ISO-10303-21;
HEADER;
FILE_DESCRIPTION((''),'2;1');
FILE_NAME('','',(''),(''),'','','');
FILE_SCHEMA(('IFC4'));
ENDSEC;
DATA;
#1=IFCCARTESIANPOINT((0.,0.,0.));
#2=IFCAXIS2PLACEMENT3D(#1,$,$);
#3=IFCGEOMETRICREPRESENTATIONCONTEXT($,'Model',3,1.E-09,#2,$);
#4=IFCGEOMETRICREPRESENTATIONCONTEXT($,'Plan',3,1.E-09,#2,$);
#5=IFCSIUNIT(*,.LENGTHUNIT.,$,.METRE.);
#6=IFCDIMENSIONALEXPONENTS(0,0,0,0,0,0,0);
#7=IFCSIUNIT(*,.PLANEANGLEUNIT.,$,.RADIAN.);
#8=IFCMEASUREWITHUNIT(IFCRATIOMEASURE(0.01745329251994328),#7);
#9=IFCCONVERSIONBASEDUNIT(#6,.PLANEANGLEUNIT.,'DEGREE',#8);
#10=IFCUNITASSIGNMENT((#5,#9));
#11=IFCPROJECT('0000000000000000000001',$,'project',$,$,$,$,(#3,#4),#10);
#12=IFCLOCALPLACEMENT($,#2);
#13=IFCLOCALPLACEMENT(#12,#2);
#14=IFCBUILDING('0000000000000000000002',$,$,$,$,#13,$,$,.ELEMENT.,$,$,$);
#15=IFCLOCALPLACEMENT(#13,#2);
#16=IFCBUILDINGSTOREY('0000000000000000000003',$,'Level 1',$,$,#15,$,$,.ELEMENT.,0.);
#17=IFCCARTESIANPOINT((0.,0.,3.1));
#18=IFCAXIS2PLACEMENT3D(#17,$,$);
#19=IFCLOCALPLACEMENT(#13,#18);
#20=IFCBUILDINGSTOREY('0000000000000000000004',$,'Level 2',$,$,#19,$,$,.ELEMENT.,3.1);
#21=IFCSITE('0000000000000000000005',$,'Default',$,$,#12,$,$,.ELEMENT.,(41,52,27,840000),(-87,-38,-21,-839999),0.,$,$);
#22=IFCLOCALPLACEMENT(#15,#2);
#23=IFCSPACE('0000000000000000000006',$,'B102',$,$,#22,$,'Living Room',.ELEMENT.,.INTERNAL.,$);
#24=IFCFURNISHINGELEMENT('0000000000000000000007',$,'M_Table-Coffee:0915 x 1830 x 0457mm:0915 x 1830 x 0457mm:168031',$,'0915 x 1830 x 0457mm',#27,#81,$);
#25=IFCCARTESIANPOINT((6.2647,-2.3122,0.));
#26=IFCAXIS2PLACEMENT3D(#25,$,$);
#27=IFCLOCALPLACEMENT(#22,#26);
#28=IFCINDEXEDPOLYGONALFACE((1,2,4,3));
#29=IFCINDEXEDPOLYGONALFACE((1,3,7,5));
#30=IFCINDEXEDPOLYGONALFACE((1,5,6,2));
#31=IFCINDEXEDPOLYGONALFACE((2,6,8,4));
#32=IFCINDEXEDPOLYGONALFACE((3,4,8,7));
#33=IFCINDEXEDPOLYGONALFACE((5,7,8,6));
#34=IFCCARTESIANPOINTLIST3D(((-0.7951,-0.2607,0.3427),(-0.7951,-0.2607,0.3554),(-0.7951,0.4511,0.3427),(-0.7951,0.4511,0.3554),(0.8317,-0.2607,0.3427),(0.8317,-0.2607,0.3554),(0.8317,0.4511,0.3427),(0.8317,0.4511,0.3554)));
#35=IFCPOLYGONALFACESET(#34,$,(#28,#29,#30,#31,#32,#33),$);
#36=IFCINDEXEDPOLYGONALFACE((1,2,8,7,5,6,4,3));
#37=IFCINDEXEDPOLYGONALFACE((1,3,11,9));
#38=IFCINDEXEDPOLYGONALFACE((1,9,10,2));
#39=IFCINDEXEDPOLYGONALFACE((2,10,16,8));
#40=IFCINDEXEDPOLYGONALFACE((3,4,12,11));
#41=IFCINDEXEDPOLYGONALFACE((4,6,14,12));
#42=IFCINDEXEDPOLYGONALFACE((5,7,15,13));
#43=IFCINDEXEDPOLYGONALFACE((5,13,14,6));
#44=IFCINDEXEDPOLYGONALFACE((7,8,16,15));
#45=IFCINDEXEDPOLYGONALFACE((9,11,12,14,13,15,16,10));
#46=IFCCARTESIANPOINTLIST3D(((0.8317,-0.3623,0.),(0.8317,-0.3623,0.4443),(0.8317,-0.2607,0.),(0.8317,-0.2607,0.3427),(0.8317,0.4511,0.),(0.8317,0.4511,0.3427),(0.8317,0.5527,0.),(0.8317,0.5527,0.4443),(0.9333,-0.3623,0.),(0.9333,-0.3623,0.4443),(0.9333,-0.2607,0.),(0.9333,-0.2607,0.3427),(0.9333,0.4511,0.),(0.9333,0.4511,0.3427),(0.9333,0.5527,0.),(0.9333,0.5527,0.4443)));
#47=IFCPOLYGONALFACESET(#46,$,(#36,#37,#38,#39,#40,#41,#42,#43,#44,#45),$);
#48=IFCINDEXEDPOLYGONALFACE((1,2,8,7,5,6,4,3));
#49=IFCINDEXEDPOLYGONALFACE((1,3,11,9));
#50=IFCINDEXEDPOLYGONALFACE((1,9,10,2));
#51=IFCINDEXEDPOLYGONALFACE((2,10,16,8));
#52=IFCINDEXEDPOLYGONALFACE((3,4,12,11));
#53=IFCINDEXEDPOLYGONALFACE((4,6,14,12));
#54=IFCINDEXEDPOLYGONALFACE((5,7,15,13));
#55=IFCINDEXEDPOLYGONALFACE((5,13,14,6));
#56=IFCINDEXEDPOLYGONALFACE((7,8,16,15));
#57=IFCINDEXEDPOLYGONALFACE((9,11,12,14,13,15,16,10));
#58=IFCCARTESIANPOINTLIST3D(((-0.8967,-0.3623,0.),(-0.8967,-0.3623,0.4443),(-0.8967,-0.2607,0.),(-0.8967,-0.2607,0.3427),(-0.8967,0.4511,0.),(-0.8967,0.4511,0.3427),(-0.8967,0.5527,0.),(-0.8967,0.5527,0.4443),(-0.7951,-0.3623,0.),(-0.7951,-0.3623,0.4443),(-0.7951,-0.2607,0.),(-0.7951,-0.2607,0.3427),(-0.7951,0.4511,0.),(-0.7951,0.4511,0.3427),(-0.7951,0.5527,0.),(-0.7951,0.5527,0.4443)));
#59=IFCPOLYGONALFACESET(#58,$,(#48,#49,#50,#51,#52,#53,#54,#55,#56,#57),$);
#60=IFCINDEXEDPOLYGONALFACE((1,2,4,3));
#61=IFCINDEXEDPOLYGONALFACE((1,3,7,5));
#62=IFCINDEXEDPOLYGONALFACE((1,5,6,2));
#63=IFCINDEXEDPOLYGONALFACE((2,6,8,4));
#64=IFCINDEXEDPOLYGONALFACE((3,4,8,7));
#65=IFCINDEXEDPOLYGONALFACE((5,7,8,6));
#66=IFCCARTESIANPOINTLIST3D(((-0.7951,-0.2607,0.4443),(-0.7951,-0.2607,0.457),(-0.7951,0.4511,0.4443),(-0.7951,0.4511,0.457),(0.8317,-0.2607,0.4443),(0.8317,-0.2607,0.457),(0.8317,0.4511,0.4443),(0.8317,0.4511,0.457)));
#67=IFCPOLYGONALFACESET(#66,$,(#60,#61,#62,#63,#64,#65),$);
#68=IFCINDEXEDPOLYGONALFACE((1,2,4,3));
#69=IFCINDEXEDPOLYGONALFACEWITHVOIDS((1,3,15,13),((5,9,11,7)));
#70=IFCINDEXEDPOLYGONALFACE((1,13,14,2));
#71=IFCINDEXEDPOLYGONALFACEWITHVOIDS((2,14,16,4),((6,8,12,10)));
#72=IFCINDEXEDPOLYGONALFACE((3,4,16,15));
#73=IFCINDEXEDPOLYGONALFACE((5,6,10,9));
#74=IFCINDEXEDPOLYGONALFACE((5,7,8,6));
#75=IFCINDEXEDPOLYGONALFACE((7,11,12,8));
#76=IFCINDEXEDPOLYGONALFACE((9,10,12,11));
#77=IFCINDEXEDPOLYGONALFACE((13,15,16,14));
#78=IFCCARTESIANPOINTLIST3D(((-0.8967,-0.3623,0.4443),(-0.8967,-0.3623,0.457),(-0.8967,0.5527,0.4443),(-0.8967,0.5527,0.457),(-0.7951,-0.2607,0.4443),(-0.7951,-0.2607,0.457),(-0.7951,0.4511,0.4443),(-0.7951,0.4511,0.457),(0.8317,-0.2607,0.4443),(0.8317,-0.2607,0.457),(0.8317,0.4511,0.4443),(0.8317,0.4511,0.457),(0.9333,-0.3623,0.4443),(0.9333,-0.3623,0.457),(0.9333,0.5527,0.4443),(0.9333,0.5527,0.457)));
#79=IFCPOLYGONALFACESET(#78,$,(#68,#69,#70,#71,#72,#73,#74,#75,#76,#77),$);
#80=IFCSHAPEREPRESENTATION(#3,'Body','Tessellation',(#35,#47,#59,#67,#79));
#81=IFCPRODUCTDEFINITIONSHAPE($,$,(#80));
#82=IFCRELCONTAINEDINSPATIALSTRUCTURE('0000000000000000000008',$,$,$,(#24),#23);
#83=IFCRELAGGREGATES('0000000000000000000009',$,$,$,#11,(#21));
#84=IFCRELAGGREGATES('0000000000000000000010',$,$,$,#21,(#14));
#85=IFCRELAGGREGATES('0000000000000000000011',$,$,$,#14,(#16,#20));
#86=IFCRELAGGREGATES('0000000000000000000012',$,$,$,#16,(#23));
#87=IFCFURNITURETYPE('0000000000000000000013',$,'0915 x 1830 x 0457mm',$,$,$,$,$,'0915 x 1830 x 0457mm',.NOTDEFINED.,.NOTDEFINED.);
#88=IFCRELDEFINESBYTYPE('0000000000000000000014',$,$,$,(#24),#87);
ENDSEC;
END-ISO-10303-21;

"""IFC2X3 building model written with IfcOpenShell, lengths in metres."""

from ifc_helpers import new_model, entity, si_unit, converted_unit, frame, origin, origin_2d_with_axis, place, context, project, spatial, polyline, rectangle, outline, extrude, source, transform, mapped, type_object, type_shapes, element, save


model = new_model("IFC2X3")

# Units and contexts
model_context = context("Model", 3, precision=1e-09, world=origin())
plan_context = context("Plan", 3, precision=1e-09, world=origin())
ifc_project = project(units=[si_unit("LENGTHUNIT", "METRE"), converted_unit("PLANEANGLEUNIT", "DEGREE", entity("IfcRatioMeasure", 0.01745329251994328), si_unit("PLANEANGLEUNIT", "RADIAN"), dimensions=[0, 0, 0, 0, 0, 0, 0])], contexts=[model_context, plan_context])

# Site, building, storey
site_placement = place(None, origin())
site = spatial("IfcSite", under=ifc_project, at=site_placement, Name="Default", CompositionType="ELEMENT", RefLatitude=(41, 52, 27, 840000), RefLongitude=(-87, -38, -21, -839999), RefElevation=0.0)
building_placement = place(site_placement, origin())
building = spatial("IfcBuilding", under=site, at=building_placement, CompositionType="ELEMENT")
storey_1_placement = place(building_placement, origin())
storey_1 = spatial("IfcBuildingStorey", under=building, at=storey_1_placement, Name="Level 1", CompositionType="ELEMENT", Elevation=0.0)

# Shared definitions
storey_2_placement = place(building_placement, frame((0.0, 0.0, 3.1)))
storey_2 = spatial("IfcBuildingStorey", under=building, at=storey_2_placement, Name="Level 2", CompositionType="ELEMENT", Elevation=3.1)

# Shared definitions
space_1_placement = place(storey_1_placement, origin())
space_1 = spatial("IfcSpace", under=storey_1, at=space_1_placement, Name="B102", LongName="Living Room", CompositionType="ELEMENT", InteriorOrExteriorSpace="INTERNAL")

# Furnishing element
furniture_type_1 = type_object("IfcFurnitureType", Name="0915 x 1830 x 0457mm", ElementType="0915 x 1830 x 0457mm", AssemblyPlace="NOTDEFINED")
shared_shape_1 = source(origin(), model_context, "Body", "SweptSolid", [
    extrude(rectangle(XDim=1.6268, YDim=0.7118, at=origin_2d_with_axis()), frame((0.0183, 0.0952, 0.3427), z_axis=(0.0, 0.0, 1.0), x_axis=(-1.0, 0.0, 0.0)), (0.0, 0.0, 1.0), 0.0127),
    extrude(outline(polyline([(-0.1967, -0.4575), (0.2475, -0.4575), (0.2475, 0.4575), (-0.1967, 0.4575), (-0.1967, 0.3559), (0.146, 0.3559), (0.146, -0.3559), (-0.1967, -0.3559), (-0.1967, -0.4575)])), frame((0.8317, 0.0952, 0.1967), z_axis=(1.0, 0.0, 0.0), x_axis=(0.0, 0.0, 1.0)), (0.0, 0.0, 1.0), 0.1016),
    extrude(outline(polyline([(-0.4575, -0.2476), (0.4575, -0.2476), (0.4575, 0.1968), (0.3559, 0.1968), (0.3559, -0.1459), (-0.3559, -0.1459), (-0.3559, 0.1968), (-0.4575, 0.1968), (-0.4575, -0.2476)])), frame((-0.8967, 0.0952, 0.1968), z_axis=(1.0, 0.0, 0.0), x_axis=(0.0, -1.0, 0.0)), (0.0, 0.0, 1.0), 0.1016),
    extrude(rectangle(XDim=1.6268, YDim=0.7118, at=origin_2d_with_axis()), frame((0.0183, 0.0952, 0.4443), z_axis=(0.0, 0.0, 1.0), x_axis=(-1.0, 0.0, 0.0)), (0.0, 0.0, 1.0), 0.0127),
    extrude(outline(polyline([(-0.915, -0.4575), (0.915, -0.4575), (0.915, 0.4575), (-0.915, 0.4575), (-0.915, -0.4575)]), holes=[polyline([(-0.8134, -0.3559), (-0.8134, 0.3559), (0.8134, 0.3559), (0.8134, -0.3559), (-0.8134, -0.3559)])]), frame((0.0183, 0.0952, 0.4443), z_axis=(0.0, 0.0, 1.0), x_axis=(-1.0, 0.0, 0.0)), (0.0, 0.0, 1.0), 0.0127),
])
type_shapes(furniture_type_1, [shared_shape_1])
furnishing_1_placement = place(space_1_placement, frame((6.2647, -2.3122, 0.0)))
element("IfcFurnishingElement", 1, at=furnishing_1_placement, inside=space_1, type_object=furniture_type_1, Name="M_Table-Coffee:0915 x 1830 x 0457mm:0915 x 1830 x 0457mm:168031", ObjectType="0915 x 1830 x 0457mm", context=model_context, shape_type="MappedRepresentation", body=[
    mapped(shared_shape_1, transform((0.0, 0.0, 0.0), scale=1.0)),
])

save(model, "model.ifc")
